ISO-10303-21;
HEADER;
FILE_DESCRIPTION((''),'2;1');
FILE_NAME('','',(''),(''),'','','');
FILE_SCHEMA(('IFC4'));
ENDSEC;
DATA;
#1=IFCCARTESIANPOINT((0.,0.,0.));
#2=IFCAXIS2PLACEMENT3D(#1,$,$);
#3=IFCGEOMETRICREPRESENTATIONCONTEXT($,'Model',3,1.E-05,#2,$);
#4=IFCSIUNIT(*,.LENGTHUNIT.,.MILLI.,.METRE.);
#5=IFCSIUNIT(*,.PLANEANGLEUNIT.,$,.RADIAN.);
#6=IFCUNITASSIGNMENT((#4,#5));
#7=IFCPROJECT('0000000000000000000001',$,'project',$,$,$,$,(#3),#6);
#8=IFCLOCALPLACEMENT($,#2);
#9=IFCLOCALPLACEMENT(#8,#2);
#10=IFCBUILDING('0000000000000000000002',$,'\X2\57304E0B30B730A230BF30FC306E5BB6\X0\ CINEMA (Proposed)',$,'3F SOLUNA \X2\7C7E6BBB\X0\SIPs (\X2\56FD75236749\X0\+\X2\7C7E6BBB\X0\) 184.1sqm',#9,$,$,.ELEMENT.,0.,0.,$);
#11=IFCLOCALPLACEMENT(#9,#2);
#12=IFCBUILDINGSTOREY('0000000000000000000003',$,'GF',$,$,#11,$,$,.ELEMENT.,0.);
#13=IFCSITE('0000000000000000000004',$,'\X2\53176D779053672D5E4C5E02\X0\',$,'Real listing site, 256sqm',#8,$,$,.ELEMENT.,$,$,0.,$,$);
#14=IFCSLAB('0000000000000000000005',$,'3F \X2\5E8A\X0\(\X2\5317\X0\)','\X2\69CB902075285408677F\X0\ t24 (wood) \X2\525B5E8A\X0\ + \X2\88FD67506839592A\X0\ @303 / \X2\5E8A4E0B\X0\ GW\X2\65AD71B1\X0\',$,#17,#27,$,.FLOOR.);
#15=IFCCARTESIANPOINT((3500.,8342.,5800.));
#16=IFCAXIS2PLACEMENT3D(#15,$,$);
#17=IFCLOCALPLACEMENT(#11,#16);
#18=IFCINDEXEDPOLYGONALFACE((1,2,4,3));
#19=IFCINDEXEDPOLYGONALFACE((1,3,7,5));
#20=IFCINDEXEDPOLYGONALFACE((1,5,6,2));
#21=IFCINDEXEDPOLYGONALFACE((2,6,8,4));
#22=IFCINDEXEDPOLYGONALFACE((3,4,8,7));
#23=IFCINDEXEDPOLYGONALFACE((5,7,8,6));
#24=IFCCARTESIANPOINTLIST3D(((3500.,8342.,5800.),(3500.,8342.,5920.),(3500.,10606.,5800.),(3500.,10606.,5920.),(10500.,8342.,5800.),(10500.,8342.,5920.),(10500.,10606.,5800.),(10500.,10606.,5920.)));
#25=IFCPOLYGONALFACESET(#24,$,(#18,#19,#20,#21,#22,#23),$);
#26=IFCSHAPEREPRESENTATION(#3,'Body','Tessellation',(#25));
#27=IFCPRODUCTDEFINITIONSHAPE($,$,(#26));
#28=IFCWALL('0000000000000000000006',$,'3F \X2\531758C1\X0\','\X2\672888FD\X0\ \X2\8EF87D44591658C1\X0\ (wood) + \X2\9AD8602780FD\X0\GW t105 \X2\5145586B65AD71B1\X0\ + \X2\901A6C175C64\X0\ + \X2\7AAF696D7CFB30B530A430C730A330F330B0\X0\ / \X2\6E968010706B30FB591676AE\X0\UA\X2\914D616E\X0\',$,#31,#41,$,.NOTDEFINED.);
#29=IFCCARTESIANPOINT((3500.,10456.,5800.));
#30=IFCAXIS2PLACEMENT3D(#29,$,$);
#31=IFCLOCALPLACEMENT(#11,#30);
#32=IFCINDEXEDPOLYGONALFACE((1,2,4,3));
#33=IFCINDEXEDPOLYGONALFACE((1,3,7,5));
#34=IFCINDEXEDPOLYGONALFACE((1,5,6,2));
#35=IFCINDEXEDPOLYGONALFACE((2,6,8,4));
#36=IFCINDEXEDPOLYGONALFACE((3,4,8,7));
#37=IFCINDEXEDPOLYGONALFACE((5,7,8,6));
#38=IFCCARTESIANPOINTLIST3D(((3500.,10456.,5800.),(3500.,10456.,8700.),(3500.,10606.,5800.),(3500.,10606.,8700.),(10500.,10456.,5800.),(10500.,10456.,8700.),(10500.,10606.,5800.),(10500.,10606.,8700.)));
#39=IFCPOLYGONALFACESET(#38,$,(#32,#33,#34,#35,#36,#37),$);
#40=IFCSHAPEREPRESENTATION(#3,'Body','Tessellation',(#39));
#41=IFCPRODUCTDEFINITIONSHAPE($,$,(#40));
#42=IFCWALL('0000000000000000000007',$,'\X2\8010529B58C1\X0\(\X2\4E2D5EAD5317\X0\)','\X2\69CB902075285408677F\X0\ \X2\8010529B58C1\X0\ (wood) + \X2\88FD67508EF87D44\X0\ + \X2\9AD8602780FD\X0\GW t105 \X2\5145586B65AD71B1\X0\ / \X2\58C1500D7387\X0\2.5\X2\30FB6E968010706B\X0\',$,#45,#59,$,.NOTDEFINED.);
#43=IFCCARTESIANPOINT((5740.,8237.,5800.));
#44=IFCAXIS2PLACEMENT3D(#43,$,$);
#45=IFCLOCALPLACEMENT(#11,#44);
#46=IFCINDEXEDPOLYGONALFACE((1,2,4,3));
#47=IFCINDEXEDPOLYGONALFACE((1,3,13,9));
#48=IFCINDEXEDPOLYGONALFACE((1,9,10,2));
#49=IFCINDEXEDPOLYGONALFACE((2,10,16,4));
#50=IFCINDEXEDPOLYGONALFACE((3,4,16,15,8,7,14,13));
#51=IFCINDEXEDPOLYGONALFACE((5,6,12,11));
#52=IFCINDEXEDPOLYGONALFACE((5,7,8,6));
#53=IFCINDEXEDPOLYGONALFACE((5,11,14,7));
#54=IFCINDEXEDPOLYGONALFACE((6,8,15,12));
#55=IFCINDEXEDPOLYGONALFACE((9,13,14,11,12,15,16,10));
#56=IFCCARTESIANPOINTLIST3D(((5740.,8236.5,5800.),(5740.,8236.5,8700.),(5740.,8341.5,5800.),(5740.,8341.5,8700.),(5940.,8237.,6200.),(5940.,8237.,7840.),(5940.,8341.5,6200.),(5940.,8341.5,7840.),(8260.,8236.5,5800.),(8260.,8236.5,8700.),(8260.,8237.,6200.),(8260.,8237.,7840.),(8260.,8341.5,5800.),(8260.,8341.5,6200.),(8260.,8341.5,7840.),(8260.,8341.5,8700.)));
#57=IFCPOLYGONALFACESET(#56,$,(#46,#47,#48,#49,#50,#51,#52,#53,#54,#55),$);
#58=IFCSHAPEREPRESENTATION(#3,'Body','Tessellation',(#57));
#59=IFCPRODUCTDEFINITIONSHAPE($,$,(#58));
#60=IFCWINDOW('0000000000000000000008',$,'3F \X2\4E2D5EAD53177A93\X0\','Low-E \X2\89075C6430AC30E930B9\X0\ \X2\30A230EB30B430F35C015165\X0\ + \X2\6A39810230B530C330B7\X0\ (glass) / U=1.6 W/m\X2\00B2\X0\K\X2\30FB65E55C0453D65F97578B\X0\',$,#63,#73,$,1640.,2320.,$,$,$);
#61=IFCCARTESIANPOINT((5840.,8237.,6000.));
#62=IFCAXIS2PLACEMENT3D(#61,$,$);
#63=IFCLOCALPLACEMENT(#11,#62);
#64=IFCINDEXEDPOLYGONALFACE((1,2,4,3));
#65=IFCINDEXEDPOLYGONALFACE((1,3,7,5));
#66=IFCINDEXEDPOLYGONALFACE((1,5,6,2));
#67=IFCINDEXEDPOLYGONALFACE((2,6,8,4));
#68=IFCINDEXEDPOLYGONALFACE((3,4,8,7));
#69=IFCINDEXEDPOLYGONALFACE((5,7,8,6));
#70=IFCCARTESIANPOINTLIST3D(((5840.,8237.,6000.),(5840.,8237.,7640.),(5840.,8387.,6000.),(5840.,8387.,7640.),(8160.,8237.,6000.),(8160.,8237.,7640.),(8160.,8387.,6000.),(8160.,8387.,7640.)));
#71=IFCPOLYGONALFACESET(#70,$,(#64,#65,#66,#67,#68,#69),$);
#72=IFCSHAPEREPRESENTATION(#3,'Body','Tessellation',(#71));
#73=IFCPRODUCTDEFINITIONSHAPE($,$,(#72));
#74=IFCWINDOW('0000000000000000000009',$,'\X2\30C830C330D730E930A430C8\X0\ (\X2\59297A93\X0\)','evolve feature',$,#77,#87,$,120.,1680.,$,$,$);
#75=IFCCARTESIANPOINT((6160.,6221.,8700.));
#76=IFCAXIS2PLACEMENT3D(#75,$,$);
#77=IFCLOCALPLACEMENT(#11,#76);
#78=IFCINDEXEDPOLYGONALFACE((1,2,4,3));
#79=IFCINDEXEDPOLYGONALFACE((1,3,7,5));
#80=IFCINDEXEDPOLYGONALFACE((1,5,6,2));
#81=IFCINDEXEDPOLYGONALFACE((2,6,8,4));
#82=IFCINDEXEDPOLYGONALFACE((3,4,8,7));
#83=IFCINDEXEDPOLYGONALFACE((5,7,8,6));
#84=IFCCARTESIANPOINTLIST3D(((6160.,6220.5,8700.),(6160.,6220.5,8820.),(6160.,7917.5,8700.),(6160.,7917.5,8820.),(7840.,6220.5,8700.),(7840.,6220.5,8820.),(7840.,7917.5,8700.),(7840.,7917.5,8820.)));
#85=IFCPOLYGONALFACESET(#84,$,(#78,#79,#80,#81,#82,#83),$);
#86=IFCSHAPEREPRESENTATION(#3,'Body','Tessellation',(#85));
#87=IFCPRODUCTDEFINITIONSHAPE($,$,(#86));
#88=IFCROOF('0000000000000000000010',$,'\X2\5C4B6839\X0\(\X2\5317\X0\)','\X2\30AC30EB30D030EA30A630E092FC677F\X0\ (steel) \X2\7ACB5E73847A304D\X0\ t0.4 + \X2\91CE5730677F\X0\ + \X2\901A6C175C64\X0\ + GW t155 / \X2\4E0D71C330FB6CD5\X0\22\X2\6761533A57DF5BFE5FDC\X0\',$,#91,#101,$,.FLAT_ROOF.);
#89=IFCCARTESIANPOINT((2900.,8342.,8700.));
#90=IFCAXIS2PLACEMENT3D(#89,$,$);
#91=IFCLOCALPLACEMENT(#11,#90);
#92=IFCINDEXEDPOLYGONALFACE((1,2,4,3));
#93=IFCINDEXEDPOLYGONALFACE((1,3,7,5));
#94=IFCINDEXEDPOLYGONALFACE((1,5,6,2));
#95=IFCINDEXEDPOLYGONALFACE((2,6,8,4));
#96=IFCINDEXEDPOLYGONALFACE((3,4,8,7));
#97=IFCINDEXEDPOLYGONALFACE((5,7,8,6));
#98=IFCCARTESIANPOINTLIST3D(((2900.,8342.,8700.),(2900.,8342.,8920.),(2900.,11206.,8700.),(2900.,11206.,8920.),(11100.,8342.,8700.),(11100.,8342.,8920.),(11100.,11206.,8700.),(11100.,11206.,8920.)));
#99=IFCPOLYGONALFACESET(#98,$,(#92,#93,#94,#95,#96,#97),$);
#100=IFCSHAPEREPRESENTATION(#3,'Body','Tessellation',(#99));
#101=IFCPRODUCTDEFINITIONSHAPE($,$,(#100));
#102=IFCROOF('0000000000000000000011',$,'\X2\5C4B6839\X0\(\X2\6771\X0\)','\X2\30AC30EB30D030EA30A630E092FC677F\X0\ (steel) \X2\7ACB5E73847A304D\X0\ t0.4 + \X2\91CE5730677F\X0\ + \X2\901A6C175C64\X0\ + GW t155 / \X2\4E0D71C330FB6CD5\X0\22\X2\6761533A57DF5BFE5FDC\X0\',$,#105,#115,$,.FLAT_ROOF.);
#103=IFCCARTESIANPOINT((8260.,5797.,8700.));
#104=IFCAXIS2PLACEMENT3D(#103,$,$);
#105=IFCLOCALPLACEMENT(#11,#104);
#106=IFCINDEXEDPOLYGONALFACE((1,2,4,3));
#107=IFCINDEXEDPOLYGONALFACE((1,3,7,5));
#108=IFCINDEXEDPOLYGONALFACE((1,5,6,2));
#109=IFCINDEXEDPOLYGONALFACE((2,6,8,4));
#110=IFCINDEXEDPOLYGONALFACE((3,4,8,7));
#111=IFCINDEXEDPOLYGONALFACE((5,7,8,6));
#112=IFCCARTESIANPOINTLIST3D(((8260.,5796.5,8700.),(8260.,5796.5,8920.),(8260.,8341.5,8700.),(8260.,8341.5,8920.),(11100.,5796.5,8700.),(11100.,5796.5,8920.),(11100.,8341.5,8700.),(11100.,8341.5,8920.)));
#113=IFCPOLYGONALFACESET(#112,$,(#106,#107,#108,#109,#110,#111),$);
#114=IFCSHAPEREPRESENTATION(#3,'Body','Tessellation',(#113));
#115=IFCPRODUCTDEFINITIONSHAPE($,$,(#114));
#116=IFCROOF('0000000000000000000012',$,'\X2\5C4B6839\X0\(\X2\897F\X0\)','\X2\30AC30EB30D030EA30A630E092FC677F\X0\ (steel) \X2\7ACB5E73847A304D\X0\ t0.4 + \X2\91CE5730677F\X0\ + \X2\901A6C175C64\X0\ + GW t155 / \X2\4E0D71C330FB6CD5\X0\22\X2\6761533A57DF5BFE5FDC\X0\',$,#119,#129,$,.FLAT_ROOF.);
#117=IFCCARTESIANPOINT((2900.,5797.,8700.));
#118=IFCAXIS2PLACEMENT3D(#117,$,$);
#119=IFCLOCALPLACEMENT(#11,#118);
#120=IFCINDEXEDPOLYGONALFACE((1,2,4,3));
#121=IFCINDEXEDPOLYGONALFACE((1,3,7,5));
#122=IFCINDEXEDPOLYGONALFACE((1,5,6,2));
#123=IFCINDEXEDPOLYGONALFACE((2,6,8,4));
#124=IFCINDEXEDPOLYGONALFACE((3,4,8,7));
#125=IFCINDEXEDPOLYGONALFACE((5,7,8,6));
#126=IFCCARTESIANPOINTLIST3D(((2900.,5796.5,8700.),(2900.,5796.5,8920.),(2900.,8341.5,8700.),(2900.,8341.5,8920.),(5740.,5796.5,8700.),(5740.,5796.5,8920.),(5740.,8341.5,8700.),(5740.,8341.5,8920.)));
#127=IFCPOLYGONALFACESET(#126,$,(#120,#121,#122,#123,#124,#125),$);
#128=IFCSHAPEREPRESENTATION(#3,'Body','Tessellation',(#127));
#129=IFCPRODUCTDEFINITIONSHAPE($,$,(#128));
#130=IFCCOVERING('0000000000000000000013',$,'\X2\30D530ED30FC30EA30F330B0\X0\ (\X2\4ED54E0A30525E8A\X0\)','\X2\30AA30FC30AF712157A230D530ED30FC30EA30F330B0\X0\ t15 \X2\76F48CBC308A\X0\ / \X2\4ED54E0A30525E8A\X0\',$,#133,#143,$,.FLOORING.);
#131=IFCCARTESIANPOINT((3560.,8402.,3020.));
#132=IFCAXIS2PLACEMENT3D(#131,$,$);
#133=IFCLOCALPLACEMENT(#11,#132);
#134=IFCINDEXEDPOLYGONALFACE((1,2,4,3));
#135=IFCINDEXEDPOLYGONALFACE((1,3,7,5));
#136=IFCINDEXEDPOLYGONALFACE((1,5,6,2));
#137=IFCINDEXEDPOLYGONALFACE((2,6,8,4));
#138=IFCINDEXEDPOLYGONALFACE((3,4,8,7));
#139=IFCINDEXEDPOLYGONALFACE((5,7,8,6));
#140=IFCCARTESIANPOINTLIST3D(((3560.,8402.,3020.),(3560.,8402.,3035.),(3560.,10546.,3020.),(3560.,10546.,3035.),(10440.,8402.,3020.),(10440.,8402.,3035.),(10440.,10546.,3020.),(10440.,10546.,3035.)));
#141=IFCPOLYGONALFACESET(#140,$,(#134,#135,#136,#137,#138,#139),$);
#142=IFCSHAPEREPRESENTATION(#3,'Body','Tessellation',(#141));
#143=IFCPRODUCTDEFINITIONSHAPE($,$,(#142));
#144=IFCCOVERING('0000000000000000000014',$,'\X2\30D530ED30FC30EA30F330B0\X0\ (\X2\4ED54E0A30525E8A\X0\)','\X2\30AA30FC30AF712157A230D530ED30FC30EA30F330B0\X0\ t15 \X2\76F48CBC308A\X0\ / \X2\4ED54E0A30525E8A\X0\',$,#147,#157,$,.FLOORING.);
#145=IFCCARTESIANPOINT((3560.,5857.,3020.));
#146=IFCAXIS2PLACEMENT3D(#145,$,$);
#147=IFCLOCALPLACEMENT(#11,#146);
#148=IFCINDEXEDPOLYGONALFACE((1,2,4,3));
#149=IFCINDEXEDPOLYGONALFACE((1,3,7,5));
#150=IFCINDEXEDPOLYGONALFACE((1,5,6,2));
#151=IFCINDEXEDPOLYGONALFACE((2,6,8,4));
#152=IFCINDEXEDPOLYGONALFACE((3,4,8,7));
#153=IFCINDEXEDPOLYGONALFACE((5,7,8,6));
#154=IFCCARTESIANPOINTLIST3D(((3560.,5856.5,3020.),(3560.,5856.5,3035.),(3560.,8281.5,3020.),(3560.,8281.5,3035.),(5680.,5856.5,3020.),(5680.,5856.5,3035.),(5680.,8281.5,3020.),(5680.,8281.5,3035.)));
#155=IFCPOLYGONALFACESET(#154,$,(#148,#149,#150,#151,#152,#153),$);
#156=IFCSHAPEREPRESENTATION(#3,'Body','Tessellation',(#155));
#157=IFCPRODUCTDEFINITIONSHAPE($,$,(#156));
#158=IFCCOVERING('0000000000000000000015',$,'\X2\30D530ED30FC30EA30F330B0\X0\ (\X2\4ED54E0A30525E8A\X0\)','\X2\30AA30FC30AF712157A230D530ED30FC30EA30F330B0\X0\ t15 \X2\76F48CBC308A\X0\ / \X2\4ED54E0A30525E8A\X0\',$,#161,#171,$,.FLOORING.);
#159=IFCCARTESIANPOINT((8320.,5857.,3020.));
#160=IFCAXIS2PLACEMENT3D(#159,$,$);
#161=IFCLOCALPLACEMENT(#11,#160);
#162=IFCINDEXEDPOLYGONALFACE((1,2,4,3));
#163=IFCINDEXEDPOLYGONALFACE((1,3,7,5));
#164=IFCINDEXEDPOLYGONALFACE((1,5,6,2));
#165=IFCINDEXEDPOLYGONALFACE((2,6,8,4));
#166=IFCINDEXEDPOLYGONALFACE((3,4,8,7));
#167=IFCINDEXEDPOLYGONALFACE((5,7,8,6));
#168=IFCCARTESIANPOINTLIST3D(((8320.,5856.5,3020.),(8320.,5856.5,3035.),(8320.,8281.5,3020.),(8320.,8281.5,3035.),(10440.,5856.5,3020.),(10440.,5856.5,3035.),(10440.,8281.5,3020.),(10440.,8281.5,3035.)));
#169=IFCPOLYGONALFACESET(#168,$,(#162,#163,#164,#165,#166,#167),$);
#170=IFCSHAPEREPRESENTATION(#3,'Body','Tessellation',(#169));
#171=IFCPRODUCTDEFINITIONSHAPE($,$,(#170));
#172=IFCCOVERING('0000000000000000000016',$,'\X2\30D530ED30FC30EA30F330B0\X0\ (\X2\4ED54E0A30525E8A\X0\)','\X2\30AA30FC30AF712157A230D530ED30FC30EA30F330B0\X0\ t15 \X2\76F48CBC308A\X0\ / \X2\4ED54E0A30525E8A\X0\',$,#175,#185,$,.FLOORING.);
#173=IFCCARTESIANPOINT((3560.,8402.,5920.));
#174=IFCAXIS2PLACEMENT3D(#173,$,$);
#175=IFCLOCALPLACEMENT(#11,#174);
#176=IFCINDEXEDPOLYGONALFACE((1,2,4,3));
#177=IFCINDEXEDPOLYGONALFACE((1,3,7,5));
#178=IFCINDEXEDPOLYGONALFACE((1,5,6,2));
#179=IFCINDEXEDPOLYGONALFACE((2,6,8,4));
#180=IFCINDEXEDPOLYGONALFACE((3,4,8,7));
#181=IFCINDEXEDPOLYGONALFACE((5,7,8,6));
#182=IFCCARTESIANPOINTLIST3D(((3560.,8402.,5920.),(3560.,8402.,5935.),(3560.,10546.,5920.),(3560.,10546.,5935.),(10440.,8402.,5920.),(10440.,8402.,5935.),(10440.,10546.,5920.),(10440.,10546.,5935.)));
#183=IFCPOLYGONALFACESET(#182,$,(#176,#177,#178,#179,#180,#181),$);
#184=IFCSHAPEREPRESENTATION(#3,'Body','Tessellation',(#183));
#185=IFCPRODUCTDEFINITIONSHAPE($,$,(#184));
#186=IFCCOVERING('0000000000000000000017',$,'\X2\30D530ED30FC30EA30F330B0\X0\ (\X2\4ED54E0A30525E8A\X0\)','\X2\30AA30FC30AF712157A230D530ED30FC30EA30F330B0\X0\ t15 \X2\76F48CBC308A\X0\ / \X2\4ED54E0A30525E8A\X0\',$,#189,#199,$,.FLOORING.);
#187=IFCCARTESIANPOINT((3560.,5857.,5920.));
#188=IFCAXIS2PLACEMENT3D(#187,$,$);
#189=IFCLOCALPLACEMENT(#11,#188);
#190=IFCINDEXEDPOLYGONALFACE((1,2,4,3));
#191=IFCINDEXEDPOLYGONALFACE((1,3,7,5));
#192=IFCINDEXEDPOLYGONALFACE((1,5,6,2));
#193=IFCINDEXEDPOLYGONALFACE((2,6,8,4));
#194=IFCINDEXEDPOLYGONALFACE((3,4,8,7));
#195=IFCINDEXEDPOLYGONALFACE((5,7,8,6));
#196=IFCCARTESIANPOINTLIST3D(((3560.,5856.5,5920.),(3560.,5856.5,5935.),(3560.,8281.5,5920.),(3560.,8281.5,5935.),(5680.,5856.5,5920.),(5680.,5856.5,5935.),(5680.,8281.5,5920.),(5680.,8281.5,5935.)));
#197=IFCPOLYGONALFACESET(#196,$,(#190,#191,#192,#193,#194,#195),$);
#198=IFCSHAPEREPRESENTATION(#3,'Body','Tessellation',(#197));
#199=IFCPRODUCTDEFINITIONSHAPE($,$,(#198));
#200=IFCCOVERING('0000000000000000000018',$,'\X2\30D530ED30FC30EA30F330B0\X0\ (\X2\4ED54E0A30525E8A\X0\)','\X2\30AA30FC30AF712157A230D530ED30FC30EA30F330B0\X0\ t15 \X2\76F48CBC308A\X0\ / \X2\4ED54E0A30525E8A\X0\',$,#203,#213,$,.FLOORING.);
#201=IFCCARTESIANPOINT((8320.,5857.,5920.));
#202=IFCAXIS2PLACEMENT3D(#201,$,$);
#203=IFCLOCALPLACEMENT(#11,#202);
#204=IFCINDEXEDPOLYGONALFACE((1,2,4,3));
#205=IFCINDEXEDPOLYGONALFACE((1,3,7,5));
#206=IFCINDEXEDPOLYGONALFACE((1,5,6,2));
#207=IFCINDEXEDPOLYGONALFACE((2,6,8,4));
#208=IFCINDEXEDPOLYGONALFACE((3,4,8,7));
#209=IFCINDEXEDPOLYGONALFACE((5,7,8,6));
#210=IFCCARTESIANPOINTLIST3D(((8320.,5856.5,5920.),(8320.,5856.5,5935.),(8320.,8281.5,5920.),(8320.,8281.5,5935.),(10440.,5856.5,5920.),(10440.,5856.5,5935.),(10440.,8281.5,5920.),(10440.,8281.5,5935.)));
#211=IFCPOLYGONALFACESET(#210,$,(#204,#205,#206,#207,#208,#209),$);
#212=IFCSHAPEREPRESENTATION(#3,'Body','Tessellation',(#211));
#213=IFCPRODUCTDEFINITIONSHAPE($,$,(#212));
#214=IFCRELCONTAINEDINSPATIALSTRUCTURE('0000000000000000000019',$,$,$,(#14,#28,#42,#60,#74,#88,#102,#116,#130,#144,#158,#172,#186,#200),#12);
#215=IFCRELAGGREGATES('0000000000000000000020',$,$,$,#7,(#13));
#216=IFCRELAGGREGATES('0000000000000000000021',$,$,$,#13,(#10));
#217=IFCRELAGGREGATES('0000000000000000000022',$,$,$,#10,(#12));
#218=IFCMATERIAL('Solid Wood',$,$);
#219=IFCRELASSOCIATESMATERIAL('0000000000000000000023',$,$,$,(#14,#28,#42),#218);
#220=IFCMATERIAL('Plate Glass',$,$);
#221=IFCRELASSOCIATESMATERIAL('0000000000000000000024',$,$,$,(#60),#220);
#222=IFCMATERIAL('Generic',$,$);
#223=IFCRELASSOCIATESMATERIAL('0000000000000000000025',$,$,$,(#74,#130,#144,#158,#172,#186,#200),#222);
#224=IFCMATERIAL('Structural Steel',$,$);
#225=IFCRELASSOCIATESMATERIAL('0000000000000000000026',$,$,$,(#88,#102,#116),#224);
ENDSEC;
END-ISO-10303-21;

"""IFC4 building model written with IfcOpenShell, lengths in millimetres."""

from ifc_helpers import new_model, si_unit, frame, frame_2d, origin, place, context, project, spatial, rectangle, extrude, material, element, fill, save


model = new_model("IFC4")

# Units and contexts
model_context = context("Model", 3, precision=1e-05, world=origin())
ifc_project = project(units=[si_unit("LENGTHUNIT", "METRE", prefix="MILLI"), si_unit("PLANEANGLEUNIT", "RADIAN")], contexts=[model_context])

# Site, building, storey
site_placement = place(None, origin())
site = spatial("IfcSite", under=ifc_project, at=site_placement, Name="北海道札幌市", ObjectType="Real listing site, 256sqm", CompositionType="ELEMENT", RefElevation=0.0)
building_placement = place(site_placement, origin())
building = spatial("IfcBuilding", under=site, at=building_placement, Name="地下シアターの家 CINEMA (Proposed)", ObjectType="3F SOLUNA 籾殻SIPs (国産杉+籾殻) 184.1sqm", CompositionType="ELEMENT", ElevationOfRefHeight=0.0, ElevationOfTerrain=0.0)
storey_placement = place(building_placement, origin())
storey = spatial("IfcBuildingStorey", under=building, at=storey_placement, Name="GF", CompositionType="ELEMENT", Elevation=0.0)

# Slab
ifc_material_1 = material(Name="Solid Wood")
slab_placement = place(storey_placement, frame((3500.0, 8342.0, 5800.0)))
element("IfcSlab", 1, at=slab_placement, inside=storey, material=ifc_material_1, Name="3F 床(北)", Description="構造用合板 t24 (wood) 剛床 + 製材根太 @303 / 床下 GW断熱", PredefinedType="FLOOR", context=model_context, shape_type="SweptSolid", body=[
    extrude(rectangle(XDim=7000.0, YDim=2264.0, at=frame_2d((3500.0, 1132.0))), frame((3500.0, 8342.0, 5800.0)), (0.0, 0.0, 1.0), 120.0),
])

# Wall
wall_1_placement = place(storey_placement, frame((3500.0, 10456.0, 5800.0)))
element("IfcWall", 2, at=wall_1_placement, inside=storey, material=ifc_material_1, Name="3F 北壁", Description="木製 軸組外壁 (wood) + 高性能GW t105 充填断熱 + 通気層 + 窯業系サイディング / 準耐火・外皮UA配慮", PredefinedType="NOTDEFINED", context=model_context, shape_type="SweptSolid", body=[
    extrude(rectangle(XDim=7000.0, YDim=150.0, at=frame_2d((3500.0, 75.0))), frame((3500.0, 10456.0, 5800.0)), (0.0, 0.0, 1.0), 2900.0),
])

# Wall, opening, window
wall_2_placement = place(storey_placement, frame((5740.0, 8237.0, 5800.0)))
wall_2 = element("IfcWall", 3, at=wall_2_placement, inside=storey, material=ifc_material_1, Name="耐力壁(中庭北)", Description="構造用合板 耐力壁 (wood) + 製材軸組 + 高性能GW t105 充填断熱 / 壁倍率2.5・準耐火", PredefinedType="NOTDEFINED", context=model_context, shape_type="SweptSolid", body=[
    extrude(rectangle(XDim=2520.0, YDim=105.0, at=frame_2d((1260.0, 52.0))), frame((5740.0, 8237.0, 5800.0)), (0.0, 0.0, 1.0), 2900.0),
])
opening_placement = place(storey_placement, frame((5840.0, 8237.0, 6000.0)))
opening = element("IfcOpeningElement", 4, at=opening_placement, cuts=wall_2, PredefinedType="NOTDEFINED", context=model_context, shape_type="SweptSolid", body=[
    extrude(rectangle(XDim=2320.0, YDim=150.0, at=frame_2d((1160.0, 75.0))), frame((5840.0, 8237.0, 6000.0)), (0.0, 0.0, 1.0), 1640.0),
])
ifc_material_2 = material(Name="Plate Glass")
window_1_placement = place(storey_placement, frame((5840.0, 8237.0, 6000.0)))
window_1 = element("IfcWindow", 5, at=window_1_placement, inside=storey, material=ifc_material_2, Name="3F 中庭北窓", Description="Low-E 複層ガラス アルゴン封入 + 樹脂サッシ (glass) / U=1.6 W/m²K・日射取得型", OverallHeight=1640.0, OverallWidth=2320.0, context=model_context, shape_type="SweptSolid", body=[
    extrude(rectangle(XDim=2320.0, YDim=150.0, at=frame_2d((1160.0, 75.0))), frame((5840.0, 8237.0, 6000.0)), (0.0, 0.0, 1.0), 1640.0),
])
fill(opening, window_1)

# Window
ifc_material_3 = material(Name="Generic")
window_2_placement = place(storey_placement, frame((6160.0, 6221.0, 8700.0)))
element("IfcWindow", 6, at=window_2_placement, inside=storey, material=ifc_material_3, Name="トップライト (天窓)", Description="evolve feature", OverallHeight=120.0, OverallWidth=1680.0, context=model_context, shape_type="SweptSolid", body=[
    extrude(rectangle(XDim=1680.0, YDim=1697.0, at=frame_2d((840.0, 848.0))), frame((6160.0, 6221.0, 8700.0)), (0.0, 0.0, 1.0), 120.0),
])

# Roofs
ifc_material_4 = material(Name="Structural Steel")
roof_1_placement = place(storey_placement, frame((2900.0, 8342.0, 8700.0)))
element("IfcRoof", 7, at=roof_1_placement, inside=storey, material=ifc_material_4, Name="屋根(北)", Description="ガルバリウム鋼板 (steel) 立平葺き t0.4 + 野地板 + 通気層 + GW t155 / 不燃・法22条区域対応", PredefinedType="FLAT_ROOF", context=model_context, shape_type="SweptSolid", body=[
    extrude(rectangle(XDim=8200.0, YDim=2864.0, at=frame_2d((4100.0, 1432.0))), frame((2900.0, 8342.0, 8700.0)), (0.0, 0.0, 1.0), 220.0),
])
roof_2_placement = place(storey_placement, frame((8260.0, 5797.0, 8700.0)))
element("IfcRoof", 8, at=roof_2_placement, inside=storey, material=ifc_material_4, Name="屋根(東)", Description="ガルバリウム鋼板 (steel) 立平葺き t0.4 + 野地板 + 通気層 + GW t155 / 不燃・法22条区域対応", PredefinedType="FLAT_ROOF", context=model_context, shape_type="SweptSolid", body=[
    extrude(rectangle(XDim=2840.0, YDim=2545.0, at=frame_2d((1420.0, 1272.0))), frame((8260.0, 5797.0, 8700.0)), (0.0, 0.0, 1.0), 220.0),
])
roof_3_placement = place(storey_placement, frame((2900.0, 5797.0, 8700.0)))
element("IfcRoof", 9, at=roof_3_placement, inside=storey, material=ifc_material_4, Name="屋根(西)", Description="ガルバリウム鋼板 (steel) 立平葺き t0.4 + 野地板 + 通気層 + GW t155 / 不燃・法22条区域対応", PredefinedType="FLAT_ROOF", context=model_context, shape_type="SweptSolid", body=[
    extrude(rectangle(XDim=2840.0, YDim=2545.0, at=frame_2d((1420.0, 1272.0))), frame((2900.0, 5797.0, 8700.0)), (0.0, 0.0, 1.0), 220.0),
])

# Coverings
covering_1_placement = place(storey_placement, frame((3560.0, 8402.0, 3020.0)))
element("IfcCovering", 10, at=covering_1_placement, inside=storey, material=ifc_material_3, Name="フローリング (仕上げ床)", Description="オーク無垢フローリング t15 直貼り / 仕上げ床", PredefinedType="FLOORING", context=model_context, shape_type="SweptSolid", body=[
    extrude(rectangle(XDim=6880.0, YDim=2144.0, at=frame_2d((3440.0, 1072.0))), frame((3560.0, 8402.0, 3020.0)), (0.0, 0.0, 1.0), 15.0),
])
covering_2_placement = place(storey_placement, frame((3560.0, 5857.0, 3020.0)))
element("IfcCovering", 11, at=covering_2_placement, inside=storey, material=ifc_material_3, Name="フローリング (仕上げ床)", Description="オーク無垢フローリング t15 直貼り / 仕上げ床", PredefinedType="FLOORING", context=model_context, shape_type="SweptSolid", body=[
    extrude(rectangle(XDim=2120.0, YDim=2425.0, at=frame_2d((1060.0, 1212.0))), frame((3560.0, 5857.0, 3020.0)), (0.0, 0.0, 1.0), 15.0),
])
covering_3_placement = place(storey_placement, frame((8320.0, 5857.0, 3020.0)))
element("IfcCovering", 12, at=covering_3_placement, inside=storey, material=ifc_material_3, Name="フローリング (仕上げ床)", Description="オーク無垢フローリング t15 直貼り / 仕上げ床", PredefinedType="FLOORING", context=model_context, shape_type="SweptSolid", body=[
    extrude(rectangle(XDim=2120.0, YDim=2425.0, at=frame_2d((1060.0, 1212.0))), frame((8320.0, 5857.0, 3020.0)), (0.0, 0.0, 1.0), 15.0),
])
covering_4_placement = place(storey_placement, frame((3560.0, 8402.0, 5920.0)))
element("IfcCovering", 13, at=covering_4_placement, inside=storey, material=ifc_material_3, Name="フローリング (仕上げ床)", Description="オーク無垢フローリング t15 直貼り / 仕上げ床", PredefinedType="FLOORING", context=model_context, shape_type="SweptSolid", body=[
    extrude(rectangle(XDim=6880.0, YDim=2144.0, at=frame_2d((3440.0, 1072.0))), frame((3560.0, 8402.0, 5920.0)), (0.0, 0.0, 1.0), 15.0),
])
covering_5_placement = place(storey_placement, frame((3560.0, 5857.0, 5920.0)))
element("IfcCovering", 14, at=covering_5_placement, inside=storey, material=ifc_material_3, Name="フローリング (仕上げ床)", Description="オーク無垢フローリング t15 直貼り / 仕上げ床", PredefinedType="FLOORING", context=model_context, shape_type="SweptSolid", body=[
    extrude(rectangle(XDim=2120.0, YDim=2425.0, at=frame_2d((1060.0, 1212.0))), frame((3560.0, 5857.0, 5920.0)), (0.0, 0.0, 1.0), 15.0),
])
covering_6_placement = place(storey_placement, frame((8320.0, 5857.0, 5920.0)))
element("IfcCovering", 15, at=covering_6_placement, inside=storey, material=ifc_material_3, Name="フローリング (仕上げ床)", Description="オーク無垢フローリング t15 直貼り / 仕上げ床", PredefinedType="FLOORING", context=model_context, shape_type="SweptSolid", body=[
    extrude(rectangle(XDim=2120.0, YDim=2425.0, at=frame_2d((1060.0, 1212.0))), frame((8320.0, 5857.0, 5920.0)), (0.0, 0.0, 1.0), 15.0),
])

save(model, "model.ifc")
